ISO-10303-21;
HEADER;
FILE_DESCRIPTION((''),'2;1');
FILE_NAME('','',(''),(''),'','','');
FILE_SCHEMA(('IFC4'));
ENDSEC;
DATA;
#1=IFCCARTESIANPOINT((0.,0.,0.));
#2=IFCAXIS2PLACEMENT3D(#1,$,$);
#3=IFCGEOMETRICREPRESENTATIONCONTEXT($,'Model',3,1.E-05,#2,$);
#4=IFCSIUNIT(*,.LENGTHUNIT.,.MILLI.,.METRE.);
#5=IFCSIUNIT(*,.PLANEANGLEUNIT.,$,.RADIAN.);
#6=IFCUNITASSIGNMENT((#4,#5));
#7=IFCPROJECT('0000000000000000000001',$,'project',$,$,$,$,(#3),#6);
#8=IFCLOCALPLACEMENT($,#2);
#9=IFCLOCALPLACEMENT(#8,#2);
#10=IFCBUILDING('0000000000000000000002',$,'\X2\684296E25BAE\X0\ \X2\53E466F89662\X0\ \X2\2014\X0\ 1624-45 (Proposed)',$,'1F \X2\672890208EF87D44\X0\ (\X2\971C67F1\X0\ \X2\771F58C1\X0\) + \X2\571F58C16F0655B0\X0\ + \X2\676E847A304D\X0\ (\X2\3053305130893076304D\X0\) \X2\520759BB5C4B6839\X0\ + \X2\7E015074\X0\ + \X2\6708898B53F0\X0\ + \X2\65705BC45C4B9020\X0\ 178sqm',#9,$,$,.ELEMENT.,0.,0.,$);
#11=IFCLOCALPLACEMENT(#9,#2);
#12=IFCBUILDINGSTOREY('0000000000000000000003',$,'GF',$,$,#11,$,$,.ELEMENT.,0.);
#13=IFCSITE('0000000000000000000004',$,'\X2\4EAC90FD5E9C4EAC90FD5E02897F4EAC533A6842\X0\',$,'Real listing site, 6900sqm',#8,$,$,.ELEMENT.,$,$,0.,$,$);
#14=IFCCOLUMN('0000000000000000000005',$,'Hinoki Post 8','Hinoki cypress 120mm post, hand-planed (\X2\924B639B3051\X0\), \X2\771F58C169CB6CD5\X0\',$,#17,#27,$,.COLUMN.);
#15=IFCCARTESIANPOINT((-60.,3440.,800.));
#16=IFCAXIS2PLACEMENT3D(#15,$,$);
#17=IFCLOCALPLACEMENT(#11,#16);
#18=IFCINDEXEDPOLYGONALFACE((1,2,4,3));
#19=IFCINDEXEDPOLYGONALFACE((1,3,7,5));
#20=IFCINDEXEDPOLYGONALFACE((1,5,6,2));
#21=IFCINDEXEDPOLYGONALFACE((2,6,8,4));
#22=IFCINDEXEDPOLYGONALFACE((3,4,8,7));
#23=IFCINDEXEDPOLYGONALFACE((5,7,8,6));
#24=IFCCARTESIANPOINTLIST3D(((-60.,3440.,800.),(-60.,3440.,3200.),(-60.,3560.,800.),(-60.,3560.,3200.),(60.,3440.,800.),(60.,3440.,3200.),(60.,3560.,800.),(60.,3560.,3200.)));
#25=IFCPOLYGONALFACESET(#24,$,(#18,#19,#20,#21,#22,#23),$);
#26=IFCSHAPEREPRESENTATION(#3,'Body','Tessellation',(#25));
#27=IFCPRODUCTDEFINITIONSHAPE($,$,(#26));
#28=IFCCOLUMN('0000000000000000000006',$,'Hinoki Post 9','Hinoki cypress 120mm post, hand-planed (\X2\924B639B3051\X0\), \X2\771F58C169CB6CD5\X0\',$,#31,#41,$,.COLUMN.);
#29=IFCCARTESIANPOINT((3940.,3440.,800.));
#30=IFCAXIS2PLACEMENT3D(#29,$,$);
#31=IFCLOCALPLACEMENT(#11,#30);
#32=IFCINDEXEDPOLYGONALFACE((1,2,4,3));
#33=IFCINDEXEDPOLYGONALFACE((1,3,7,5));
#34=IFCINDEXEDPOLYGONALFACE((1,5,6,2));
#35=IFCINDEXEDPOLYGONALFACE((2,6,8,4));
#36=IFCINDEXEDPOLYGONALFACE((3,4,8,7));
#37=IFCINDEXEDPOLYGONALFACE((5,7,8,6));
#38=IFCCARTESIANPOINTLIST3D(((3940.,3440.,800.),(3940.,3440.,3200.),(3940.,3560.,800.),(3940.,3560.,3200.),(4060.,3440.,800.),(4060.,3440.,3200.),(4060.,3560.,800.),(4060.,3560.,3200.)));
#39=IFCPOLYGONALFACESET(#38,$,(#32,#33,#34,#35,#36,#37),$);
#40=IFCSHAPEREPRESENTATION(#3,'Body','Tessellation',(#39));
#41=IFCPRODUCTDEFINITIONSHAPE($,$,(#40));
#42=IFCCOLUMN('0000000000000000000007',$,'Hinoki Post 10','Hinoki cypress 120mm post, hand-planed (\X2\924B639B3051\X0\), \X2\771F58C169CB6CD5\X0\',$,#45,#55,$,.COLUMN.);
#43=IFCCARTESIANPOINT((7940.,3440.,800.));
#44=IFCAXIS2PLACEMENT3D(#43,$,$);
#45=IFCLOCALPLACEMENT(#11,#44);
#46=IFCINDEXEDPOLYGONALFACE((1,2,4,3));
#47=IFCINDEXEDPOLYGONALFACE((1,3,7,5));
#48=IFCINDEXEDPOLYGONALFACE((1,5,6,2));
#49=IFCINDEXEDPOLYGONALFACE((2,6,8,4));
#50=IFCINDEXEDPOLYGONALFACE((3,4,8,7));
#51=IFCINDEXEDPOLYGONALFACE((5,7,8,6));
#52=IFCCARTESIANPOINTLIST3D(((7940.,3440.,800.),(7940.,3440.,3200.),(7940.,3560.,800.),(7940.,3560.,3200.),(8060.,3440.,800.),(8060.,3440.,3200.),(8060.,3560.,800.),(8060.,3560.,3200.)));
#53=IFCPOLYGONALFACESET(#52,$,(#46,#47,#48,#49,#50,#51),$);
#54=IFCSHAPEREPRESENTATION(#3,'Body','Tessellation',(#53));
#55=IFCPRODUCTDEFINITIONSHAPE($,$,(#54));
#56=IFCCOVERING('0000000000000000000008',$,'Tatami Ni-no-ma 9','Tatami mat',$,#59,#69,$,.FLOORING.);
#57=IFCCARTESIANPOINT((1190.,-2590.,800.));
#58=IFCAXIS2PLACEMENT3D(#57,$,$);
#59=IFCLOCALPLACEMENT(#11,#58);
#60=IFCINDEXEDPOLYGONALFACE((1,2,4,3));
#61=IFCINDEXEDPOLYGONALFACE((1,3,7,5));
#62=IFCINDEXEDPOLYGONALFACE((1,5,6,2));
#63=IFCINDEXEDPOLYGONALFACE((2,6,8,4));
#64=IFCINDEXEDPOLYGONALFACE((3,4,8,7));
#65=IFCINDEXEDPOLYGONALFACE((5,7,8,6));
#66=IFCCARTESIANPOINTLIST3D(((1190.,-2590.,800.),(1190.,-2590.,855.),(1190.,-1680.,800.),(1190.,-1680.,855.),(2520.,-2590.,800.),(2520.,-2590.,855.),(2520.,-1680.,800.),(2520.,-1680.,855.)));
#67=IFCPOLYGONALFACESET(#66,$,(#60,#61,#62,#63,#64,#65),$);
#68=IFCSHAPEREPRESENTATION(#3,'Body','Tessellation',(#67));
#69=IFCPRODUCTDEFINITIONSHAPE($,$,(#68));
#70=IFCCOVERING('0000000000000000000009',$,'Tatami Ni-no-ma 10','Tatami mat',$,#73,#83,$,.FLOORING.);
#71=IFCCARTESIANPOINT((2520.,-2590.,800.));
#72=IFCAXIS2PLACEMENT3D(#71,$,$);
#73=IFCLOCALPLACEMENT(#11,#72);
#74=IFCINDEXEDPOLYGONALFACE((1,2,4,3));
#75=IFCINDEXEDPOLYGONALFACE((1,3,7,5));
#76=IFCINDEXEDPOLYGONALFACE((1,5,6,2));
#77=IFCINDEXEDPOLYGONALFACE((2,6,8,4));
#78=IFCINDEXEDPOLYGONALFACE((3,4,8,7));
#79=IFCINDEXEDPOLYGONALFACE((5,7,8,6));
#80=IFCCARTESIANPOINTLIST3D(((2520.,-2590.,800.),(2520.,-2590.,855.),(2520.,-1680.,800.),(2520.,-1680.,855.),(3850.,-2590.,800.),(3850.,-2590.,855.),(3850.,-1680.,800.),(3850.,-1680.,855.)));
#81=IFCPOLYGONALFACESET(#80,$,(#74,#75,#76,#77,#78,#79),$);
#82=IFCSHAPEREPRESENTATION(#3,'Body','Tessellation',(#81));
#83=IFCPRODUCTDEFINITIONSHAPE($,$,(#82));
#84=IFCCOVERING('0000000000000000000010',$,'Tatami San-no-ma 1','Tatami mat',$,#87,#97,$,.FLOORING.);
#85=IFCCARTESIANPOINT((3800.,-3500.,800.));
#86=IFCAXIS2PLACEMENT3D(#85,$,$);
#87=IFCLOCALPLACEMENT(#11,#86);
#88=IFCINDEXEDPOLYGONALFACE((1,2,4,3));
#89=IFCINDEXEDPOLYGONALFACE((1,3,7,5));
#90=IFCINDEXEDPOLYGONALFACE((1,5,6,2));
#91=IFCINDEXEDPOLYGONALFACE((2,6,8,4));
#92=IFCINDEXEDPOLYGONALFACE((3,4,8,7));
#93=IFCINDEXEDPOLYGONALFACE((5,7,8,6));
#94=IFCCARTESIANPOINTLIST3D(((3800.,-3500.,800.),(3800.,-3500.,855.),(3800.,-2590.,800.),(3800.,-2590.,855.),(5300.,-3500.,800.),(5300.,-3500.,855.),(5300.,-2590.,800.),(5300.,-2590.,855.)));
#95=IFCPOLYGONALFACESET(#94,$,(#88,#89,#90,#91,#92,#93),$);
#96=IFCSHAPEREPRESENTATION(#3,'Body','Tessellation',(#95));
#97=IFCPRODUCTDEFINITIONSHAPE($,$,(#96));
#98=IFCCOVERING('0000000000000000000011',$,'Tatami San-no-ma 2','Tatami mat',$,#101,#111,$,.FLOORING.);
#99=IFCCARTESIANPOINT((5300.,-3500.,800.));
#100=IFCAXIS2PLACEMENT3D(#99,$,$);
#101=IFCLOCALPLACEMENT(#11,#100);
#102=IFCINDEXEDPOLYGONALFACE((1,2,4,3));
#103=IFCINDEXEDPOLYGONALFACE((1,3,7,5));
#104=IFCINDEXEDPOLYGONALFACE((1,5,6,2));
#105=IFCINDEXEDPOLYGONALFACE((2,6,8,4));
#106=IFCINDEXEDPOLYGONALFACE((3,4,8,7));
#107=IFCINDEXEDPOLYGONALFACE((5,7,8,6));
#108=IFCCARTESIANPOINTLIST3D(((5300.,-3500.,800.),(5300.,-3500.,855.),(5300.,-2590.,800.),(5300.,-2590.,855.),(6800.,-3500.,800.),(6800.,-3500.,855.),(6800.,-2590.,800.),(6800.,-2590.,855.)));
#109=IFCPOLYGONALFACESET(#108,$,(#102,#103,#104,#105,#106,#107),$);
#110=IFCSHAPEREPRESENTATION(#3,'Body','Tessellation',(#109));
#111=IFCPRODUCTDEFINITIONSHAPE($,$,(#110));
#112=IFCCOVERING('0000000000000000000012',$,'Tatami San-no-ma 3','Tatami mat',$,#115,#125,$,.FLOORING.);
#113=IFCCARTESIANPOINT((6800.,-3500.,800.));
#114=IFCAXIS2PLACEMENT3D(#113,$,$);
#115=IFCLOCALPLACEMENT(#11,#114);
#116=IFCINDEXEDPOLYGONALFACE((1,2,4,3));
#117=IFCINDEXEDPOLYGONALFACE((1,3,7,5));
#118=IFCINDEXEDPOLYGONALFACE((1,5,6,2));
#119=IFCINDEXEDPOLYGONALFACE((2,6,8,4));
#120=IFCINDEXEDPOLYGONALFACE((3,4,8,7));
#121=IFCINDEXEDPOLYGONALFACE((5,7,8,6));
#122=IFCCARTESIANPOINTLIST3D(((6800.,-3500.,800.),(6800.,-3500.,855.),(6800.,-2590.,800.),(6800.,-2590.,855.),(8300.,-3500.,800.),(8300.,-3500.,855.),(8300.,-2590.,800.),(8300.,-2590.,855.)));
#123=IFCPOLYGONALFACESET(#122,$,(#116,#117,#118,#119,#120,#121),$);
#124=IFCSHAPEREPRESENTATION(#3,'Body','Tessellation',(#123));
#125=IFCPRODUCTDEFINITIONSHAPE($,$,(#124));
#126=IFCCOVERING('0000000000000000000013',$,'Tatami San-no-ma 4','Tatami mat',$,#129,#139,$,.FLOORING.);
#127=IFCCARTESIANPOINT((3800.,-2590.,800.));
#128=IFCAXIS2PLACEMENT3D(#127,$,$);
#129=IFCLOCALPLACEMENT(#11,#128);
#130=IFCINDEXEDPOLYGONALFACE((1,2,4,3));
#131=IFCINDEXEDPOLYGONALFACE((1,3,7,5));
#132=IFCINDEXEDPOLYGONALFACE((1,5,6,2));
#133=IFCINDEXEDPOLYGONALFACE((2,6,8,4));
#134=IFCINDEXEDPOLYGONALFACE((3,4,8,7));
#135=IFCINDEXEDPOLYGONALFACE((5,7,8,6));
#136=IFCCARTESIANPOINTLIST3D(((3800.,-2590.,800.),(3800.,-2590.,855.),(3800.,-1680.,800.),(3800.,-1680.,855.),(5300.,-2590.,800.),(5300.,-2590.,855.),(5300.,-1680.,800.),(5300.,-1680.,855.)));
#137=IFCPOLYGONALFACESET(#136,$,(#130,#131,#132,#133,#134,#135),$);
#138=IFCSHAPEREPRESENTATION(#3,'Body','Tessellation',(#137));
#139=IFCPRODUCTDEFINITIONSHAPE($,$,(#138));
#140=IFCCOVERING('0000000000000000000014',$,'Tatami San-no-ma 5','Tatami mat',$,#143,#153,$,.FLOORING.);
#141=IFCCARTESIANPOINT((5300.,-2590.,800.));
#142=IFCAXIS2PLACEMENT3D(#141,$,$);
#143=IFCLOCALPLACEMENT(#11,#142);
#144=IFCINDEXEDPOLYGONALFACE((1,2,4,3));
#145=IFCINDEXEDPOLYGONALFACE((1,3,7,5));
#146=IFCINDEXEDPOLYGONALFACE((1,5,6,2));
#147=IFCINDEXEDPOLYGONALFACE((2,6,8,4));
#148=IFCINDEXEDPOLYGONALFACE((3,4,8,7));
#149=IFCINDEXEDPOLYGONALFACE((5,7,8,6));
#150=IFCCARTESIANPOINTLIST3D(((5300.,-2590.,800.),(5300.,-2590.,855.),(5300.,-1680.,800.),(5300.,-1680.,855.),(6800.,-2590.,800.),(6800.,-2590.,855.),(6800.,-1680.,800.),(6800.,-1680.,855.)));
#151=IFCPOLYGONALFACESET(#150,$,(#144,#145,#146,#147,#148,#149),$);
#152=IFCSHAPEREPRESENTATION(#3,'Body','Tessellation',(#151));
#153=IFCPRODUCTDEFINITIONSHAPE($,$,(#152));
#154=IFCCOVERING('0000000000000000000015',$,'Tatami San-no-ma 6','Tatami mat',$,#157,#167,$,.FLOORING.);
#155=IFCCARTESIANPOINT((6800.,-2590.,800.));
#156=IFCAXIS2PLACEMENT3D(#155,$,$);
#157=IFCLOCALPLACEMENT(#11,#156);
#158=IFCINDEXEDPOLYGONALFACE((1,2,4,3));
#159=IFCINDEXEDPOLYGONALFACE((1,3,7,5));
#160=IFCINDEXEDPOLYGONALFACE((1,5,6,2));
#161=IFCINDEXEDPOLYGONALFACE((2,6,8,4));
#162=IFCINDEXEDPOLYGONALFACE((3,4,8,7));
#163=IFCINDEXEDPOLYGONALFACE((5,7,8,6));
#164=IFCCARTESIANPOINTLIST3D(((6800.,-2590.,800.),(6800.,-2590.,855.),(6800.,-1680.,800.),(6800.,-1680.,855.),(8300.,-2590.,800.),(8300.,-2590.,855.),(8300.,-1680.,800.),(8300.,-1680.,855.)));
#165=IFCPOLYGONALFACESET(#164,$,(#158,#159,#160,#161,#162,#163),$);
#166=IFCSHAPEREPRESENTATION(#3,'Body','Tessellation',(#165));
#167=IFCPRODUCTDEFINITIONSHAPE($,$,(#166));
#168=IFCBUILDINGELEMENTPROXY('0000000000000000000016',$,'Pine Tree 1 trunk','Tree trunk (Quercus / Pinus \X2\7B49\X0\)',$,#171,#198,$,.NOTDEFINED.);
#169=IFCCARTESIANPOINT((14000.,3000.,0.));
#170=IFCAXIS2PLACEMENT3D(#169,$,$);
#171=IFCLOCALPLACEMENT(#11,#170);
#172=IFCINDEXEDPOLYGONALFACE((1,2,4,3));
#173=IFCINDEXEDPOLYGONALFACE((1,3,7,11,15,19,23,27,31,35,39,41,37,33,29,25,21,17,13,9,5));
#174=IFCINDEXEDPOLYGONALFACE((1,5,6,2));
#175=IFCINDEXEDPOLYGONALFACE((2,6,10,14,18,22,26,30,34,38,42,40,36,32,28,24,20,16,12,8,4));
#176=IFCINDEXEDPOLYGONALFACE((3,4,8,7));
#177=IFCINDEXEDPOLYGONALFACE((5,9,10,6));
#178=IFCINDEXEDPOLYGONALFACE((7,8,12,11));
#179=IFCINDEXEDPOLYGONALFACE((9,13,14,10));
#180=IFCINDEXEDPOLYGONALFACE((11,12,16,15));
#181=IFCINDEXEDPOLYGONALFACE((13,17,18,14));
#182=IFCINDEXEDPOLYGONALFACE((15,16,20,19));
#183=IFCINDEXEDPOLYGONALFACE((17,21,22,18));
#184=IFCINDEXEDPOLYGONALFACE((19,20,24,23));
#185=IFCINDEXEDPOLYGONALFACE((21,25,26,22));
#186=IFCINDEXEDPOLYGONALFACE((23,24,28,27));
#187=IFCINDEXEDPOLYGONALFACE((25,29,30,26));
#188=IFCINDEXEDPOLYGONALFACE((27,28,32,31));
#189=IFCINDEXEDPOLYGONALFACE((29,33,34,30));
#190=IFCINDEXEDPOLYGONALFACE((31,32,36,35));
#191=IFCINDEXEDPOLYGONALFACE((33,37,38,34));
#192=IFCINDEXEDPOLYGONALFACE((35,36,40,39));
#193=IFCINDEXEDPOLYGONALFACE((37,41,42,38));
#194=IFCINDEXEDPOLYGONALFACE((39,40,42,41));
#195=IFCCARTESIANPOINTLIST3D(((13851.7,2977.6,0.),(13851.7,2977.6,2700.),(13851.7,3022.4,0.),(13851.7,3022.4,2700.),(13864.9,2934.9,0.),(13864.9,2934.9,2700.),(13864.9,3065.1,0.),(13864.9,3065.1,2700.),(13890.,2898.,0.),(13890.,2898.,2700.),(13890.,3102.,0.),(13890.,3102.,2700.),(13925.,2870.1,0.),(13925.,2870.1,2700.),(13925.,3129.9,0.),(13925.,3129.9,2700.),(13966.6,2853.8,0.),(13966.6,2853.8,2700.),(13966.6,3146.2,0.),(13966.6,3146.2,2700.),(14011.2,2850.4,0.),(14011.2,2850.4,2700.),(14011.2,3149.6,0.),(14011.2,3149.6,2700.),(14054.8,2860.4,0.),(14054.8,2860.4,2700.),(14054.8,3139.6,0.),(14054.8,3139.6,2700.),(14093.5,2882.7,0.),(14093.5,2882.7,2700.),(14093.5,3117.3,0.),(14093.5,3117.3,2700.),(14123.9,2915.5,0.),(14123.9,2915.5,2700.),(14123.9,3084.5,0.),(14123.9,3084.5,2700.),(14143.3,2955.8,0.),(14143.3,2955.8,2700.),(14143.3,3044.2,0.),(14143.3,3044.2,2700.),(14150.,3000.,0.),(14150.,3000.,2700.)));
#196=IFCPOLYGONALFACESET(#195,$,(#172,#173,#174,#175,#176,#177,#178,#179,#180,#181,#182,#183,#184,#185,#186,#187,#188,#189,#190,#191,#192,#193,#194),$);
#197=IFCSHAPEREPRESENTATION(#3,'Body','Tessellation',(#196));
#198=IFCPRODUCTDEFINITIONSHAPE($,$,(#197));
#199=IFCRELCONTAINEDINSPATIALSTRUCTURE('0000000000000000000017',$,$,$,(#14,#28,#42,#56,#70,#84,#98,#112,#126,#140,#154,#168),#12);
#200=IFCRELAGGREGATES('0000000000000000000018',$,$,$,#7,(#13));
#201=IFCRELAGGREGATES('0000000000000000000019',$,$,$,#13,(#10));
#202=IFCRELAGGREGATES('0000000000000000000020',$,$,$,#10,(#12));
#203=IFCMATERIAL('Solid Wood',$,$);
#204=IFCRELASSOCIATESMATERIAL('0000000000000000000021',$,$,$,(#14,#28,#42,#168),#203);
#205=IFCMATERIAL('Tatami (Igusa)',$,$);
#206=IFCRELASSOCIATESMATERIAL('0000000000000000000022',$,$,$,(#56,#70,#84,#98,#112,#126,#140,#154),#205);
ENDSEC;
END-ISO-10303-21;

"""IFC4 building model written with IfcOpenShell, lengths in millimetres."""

from ifc_helpers import new_model, si_unit, frame, frame_2d, origin, origin_2d, place, context, project, spatial, rectangle, circle, extrude, material, element, save


model = new_model("IFC4")

# Units and contexts
model_context = context("Model", 3, precision=1e-05, world=origin())
ifc_project = project(units=[si_unit("LENGTHUNIT", "METRE", prefix="MILLI"), si_unit("PLANEANGLEUNIT", "RADIAN")], contexts=[model_context])

# Site, building, storey
site_placement = place(None, origin())
site = spatial("IfcSite", under=ifc_project, at=site_placement, Name="京都府京都市西京区桂", ObjectType="Real listing site, 6900sqm", CompositionType="ELEMENT", RefElevation=0.0)
building_placement = place(site_placement, origin())
building = spatial("IfcBuilding", under=site, at=building_placement, Name="桂離宮 古書院 — 1624-45 (Proposed)", ObjectType="1F 木造軸組 (霜柱 真壁) + 土壁漆喰 + 杮葺き (こけらぶき) 切妻屋根 + 縁側 + 月見台 + 数寄屋造 178sqm", CompositionType="ELEMENT", ElevationOfRefHeight=0.0, ElevationOfTerrain=0.0)
storey_placement = place(building_placement, origin())
storey = spatial("IfcBuildingStorey", under=building, at=storey_placement, Name="GF", CompositionType="ELEMENT", Elevation=0.0)

# Columns
ifc_material_1 = material(Name="Solid Wood")
column_1_placement = place(storey_placement, frame((-60.0, 3440.0, 800.0)))
element("IfcColumn", 1, at=column_1_placement, inside=storey, material=ifc_material_1, Name="Hinoki Post 8", Description="Hinoki cypress 120mm post, hand-planed (鉋掛け), 真壁構法", PredefinedType="COLUMN", context=model_context, shape_type="SweptSolid", body=[
    extrude(rectangle(XDim=120.0, YDim=120.0, at=frame_2d((60.0, 60.0))), frame((-60.0, 3440.0, 800.0)), (0.0, 0.0, 1.0), 2400.0),
])
column_2_placement = place(storey_placement, frame((3940.0, 3440.0, 800.0)))
element("IfcColumn", 2, at=column_2_placement, inside=storey, material=ifc_material_1, Name="Hinoki Post 9", Description="Hinoki cypress 120mm post, hand-planed (鉋掛け), 真壁構法", PredefinedType="COLUMN", context=model_context, shape_type="SweptSolid", body=[
    extrude(rectangle(XDim=120.0, YDim=120.0, at=frame_2d((60.0, 60.0))), frame((3940.0, 3440.0, 800.0)), (0.0, 0.0, 1.0), 2400.0),
])
column_3_placement = place(storey_placement, frame((7940.0, 3440.0, 800.0)))
element("IfcColumn", 3, at=column_3_placement, inside=storey, material=ifc_material_1, Name="Hinoki Post 10", Description="Hinoki cypress 120mm post, hand-planed (鉋掛け), 真壁構法", PredefinedType="COLUMN", context=model_context, shape_type="SweptSolid", body=[
    extrude(rectangle(XDim=120.0, YDim=120.0, at=frame_2d((60.0, 60.0))), frame((7940.0, 3440.0, 800.0)), (0.0, 0.0, 1.0), 2400.0),
])

# Coverings
ifc_material_2 = material(Name="Tatami (Igusa)")
covering_1_placement = place(storey_placement, frame((1190.0, -2590.0, 800.0)))
element("IfcCovering", 4, at=covering_1_placement, inside=storey, material=ifc_material_2, Name="Tatami Ni-no-ma 9", Description="Tatami mat", PredefinedType="FLOORING", context=model_context, shape_type="SweptSolid", body=[
    extrude(rectangle(XDim=1330.0, YDim=910.0, at=frame_2d((665.0, 455.0))), frame((1190.0, -2590.0, 800.0)), (0.0, 0.0, 1.0), 55.0),
])
covering_2_placement = place(storey_placement, frame((2520.0, -2590.0, 800.0)))
element("IfcCovering", 5, at=covering_2_placement, inside=storey, material=ifc_material_2, Name="Tatami Ni-no-ma 10", Description="Tatami mat", PredefinedType="FLOORING", context=model_context, shape_type="SweptSolid", body=[
    extrude(rectangle(XDim=1330.0, YDim=910.0, at=frame_2d((665.0, 455.0))), frame((2520.0, -2590.0, 800.0)), (0.0, 0.0, 1.0), 55.0),
])
covering_3_placement = place(storey_placement, frame((3800.0, -3500.0, 800.0)))
element("IfcCovering", 6, at=covering_3_placement, inside=storey, material=ifc_material_2, Name="Tatami San-no-ma 1", Description="Tatami mat", PredefinedType="FLOORING", context=model_context, shape_type="SweptSolid", body=[
    extrude(rectangle(XDim=1500.0, YDim=910.0, at=frame_2d((750.0, 455.0))), frame((3800.0, -3500.0, 800.0)), (0.0, 0.0, 1.0), 55.0),
])
covering_4_placement = place(storey_placement, frame((5300.0, -3500.0, 800.0)))
element("IfcCovering", 7, at=covering_4_placement, inside=storey, material=ifc_material_2, Name="Tatami San-no-ma 2", Description="Tatami mat", PredefinedType="FLOORING", context=model_context, shape_type="SweptSolid", body=[
    extrude(rectangle(XDim=1500.0, YDim=910.0, at=frame_2d((750.0, 455.0))), frame((5300.0, -3500.0, 800.0)), (0.0, 0.0, 1.0), 55.0),
])
covering_5_placement = place(storey_placement, frame((6800.0, -3500.0, 800.0)))
element("IfcCovering", 8, at=covering_5_placement, inside=storey, material=ifc_material_2, Name="Tatami San-no-ma 3", Description="Tatami mat", PredefinedType="FLOORING", context=model_context, shape_type="SweptSolid", body=[
    extrude(rectangle(XDim=1500.0, YDim=910.0, at=frame_2d((750.0, 455.0))), frame((6800.0, -3500.0, 800.0)), (0.0, 0.0, 1.0), 55.0),
])
covering_6_placement = place(storey_placement, frame((3800.0, -2590.0, 800.0)))
element("IfcCovering", 9, at=covering_6_placement, inside=storey, material=ifc_material_2, Name="Tatami San-no-ma 4", Description="Tatami mat", PredefinedType="FLOORING", context=model_context, shape_type="SweptSolid", body=[
    extrude(rectangle(XDim=1500.0, YDim=910.0, at=frame_2d((750.0, 455.0))), frame((3800.0, -2590.0, 800.0)), (0.0, 0.0, 1.0), 55.0),
])
covering_7_placement = place(storey_placement, frame((5300.0, -2590.0, 800.0)))
element("IfcCovering", 10, at=covering_7_placement, inside=storey, material=ifc_material_2, Name="Tatami San-no-ma 5", Description="Tatami mat", PredefinedType="FLOORING", context=model_context, shape_type="SweptSolid", body=[
    extrude(rectangle(XDim=1500.0, YDim=910.0, at=frame_2d((750.0, 455.0))), frame((5300.0, -2590.0, 800.0)), (0.0, 0.0, 1.0), 55.0),
])
covering_8_placement = place(storey_placement, frame((6800.0, -2590.0, 800.0)))
element("IfcCovering", 11, at=covering_8_placement, inside=storey, material=ifc_material_2, Name="Tatami San-no-ma 6", Description="Tatami mat", PredefinedType="FLOORING", context=model_context, shape_type="SweptSolid", body=[
    extrude(rectangle(XDim=1500.0, YDim=910.0, at=frame_2d((750.0, 455.0))), frame((6800.0, -2590.0, 800.0)), (0.0, 0.0, 1.0), 55.0),
])

# Building element proxy
proxy_1_placement = place(storey_placement, frame((14000.0, 3000.0, 0.0)))
element("IfcBuildingElementProxy", 12, at=proxy_1_placement, inside=storey, material=ifc_material_1, Name="Pine Tree 1 trunk", Description="Tree trunk (Quercus / Pinus 等)", PredefinedType="NOTDEFINED", context=model_context, shape_type="SweptSolid", body=[
    extrude(circle(Radius=150.0, at=origin_2d()), frame((14000.0, 3000.0, 0.0)), (0.0, 0.0, 1.0), 2700.0),
])

save(model, "model.ifc")
